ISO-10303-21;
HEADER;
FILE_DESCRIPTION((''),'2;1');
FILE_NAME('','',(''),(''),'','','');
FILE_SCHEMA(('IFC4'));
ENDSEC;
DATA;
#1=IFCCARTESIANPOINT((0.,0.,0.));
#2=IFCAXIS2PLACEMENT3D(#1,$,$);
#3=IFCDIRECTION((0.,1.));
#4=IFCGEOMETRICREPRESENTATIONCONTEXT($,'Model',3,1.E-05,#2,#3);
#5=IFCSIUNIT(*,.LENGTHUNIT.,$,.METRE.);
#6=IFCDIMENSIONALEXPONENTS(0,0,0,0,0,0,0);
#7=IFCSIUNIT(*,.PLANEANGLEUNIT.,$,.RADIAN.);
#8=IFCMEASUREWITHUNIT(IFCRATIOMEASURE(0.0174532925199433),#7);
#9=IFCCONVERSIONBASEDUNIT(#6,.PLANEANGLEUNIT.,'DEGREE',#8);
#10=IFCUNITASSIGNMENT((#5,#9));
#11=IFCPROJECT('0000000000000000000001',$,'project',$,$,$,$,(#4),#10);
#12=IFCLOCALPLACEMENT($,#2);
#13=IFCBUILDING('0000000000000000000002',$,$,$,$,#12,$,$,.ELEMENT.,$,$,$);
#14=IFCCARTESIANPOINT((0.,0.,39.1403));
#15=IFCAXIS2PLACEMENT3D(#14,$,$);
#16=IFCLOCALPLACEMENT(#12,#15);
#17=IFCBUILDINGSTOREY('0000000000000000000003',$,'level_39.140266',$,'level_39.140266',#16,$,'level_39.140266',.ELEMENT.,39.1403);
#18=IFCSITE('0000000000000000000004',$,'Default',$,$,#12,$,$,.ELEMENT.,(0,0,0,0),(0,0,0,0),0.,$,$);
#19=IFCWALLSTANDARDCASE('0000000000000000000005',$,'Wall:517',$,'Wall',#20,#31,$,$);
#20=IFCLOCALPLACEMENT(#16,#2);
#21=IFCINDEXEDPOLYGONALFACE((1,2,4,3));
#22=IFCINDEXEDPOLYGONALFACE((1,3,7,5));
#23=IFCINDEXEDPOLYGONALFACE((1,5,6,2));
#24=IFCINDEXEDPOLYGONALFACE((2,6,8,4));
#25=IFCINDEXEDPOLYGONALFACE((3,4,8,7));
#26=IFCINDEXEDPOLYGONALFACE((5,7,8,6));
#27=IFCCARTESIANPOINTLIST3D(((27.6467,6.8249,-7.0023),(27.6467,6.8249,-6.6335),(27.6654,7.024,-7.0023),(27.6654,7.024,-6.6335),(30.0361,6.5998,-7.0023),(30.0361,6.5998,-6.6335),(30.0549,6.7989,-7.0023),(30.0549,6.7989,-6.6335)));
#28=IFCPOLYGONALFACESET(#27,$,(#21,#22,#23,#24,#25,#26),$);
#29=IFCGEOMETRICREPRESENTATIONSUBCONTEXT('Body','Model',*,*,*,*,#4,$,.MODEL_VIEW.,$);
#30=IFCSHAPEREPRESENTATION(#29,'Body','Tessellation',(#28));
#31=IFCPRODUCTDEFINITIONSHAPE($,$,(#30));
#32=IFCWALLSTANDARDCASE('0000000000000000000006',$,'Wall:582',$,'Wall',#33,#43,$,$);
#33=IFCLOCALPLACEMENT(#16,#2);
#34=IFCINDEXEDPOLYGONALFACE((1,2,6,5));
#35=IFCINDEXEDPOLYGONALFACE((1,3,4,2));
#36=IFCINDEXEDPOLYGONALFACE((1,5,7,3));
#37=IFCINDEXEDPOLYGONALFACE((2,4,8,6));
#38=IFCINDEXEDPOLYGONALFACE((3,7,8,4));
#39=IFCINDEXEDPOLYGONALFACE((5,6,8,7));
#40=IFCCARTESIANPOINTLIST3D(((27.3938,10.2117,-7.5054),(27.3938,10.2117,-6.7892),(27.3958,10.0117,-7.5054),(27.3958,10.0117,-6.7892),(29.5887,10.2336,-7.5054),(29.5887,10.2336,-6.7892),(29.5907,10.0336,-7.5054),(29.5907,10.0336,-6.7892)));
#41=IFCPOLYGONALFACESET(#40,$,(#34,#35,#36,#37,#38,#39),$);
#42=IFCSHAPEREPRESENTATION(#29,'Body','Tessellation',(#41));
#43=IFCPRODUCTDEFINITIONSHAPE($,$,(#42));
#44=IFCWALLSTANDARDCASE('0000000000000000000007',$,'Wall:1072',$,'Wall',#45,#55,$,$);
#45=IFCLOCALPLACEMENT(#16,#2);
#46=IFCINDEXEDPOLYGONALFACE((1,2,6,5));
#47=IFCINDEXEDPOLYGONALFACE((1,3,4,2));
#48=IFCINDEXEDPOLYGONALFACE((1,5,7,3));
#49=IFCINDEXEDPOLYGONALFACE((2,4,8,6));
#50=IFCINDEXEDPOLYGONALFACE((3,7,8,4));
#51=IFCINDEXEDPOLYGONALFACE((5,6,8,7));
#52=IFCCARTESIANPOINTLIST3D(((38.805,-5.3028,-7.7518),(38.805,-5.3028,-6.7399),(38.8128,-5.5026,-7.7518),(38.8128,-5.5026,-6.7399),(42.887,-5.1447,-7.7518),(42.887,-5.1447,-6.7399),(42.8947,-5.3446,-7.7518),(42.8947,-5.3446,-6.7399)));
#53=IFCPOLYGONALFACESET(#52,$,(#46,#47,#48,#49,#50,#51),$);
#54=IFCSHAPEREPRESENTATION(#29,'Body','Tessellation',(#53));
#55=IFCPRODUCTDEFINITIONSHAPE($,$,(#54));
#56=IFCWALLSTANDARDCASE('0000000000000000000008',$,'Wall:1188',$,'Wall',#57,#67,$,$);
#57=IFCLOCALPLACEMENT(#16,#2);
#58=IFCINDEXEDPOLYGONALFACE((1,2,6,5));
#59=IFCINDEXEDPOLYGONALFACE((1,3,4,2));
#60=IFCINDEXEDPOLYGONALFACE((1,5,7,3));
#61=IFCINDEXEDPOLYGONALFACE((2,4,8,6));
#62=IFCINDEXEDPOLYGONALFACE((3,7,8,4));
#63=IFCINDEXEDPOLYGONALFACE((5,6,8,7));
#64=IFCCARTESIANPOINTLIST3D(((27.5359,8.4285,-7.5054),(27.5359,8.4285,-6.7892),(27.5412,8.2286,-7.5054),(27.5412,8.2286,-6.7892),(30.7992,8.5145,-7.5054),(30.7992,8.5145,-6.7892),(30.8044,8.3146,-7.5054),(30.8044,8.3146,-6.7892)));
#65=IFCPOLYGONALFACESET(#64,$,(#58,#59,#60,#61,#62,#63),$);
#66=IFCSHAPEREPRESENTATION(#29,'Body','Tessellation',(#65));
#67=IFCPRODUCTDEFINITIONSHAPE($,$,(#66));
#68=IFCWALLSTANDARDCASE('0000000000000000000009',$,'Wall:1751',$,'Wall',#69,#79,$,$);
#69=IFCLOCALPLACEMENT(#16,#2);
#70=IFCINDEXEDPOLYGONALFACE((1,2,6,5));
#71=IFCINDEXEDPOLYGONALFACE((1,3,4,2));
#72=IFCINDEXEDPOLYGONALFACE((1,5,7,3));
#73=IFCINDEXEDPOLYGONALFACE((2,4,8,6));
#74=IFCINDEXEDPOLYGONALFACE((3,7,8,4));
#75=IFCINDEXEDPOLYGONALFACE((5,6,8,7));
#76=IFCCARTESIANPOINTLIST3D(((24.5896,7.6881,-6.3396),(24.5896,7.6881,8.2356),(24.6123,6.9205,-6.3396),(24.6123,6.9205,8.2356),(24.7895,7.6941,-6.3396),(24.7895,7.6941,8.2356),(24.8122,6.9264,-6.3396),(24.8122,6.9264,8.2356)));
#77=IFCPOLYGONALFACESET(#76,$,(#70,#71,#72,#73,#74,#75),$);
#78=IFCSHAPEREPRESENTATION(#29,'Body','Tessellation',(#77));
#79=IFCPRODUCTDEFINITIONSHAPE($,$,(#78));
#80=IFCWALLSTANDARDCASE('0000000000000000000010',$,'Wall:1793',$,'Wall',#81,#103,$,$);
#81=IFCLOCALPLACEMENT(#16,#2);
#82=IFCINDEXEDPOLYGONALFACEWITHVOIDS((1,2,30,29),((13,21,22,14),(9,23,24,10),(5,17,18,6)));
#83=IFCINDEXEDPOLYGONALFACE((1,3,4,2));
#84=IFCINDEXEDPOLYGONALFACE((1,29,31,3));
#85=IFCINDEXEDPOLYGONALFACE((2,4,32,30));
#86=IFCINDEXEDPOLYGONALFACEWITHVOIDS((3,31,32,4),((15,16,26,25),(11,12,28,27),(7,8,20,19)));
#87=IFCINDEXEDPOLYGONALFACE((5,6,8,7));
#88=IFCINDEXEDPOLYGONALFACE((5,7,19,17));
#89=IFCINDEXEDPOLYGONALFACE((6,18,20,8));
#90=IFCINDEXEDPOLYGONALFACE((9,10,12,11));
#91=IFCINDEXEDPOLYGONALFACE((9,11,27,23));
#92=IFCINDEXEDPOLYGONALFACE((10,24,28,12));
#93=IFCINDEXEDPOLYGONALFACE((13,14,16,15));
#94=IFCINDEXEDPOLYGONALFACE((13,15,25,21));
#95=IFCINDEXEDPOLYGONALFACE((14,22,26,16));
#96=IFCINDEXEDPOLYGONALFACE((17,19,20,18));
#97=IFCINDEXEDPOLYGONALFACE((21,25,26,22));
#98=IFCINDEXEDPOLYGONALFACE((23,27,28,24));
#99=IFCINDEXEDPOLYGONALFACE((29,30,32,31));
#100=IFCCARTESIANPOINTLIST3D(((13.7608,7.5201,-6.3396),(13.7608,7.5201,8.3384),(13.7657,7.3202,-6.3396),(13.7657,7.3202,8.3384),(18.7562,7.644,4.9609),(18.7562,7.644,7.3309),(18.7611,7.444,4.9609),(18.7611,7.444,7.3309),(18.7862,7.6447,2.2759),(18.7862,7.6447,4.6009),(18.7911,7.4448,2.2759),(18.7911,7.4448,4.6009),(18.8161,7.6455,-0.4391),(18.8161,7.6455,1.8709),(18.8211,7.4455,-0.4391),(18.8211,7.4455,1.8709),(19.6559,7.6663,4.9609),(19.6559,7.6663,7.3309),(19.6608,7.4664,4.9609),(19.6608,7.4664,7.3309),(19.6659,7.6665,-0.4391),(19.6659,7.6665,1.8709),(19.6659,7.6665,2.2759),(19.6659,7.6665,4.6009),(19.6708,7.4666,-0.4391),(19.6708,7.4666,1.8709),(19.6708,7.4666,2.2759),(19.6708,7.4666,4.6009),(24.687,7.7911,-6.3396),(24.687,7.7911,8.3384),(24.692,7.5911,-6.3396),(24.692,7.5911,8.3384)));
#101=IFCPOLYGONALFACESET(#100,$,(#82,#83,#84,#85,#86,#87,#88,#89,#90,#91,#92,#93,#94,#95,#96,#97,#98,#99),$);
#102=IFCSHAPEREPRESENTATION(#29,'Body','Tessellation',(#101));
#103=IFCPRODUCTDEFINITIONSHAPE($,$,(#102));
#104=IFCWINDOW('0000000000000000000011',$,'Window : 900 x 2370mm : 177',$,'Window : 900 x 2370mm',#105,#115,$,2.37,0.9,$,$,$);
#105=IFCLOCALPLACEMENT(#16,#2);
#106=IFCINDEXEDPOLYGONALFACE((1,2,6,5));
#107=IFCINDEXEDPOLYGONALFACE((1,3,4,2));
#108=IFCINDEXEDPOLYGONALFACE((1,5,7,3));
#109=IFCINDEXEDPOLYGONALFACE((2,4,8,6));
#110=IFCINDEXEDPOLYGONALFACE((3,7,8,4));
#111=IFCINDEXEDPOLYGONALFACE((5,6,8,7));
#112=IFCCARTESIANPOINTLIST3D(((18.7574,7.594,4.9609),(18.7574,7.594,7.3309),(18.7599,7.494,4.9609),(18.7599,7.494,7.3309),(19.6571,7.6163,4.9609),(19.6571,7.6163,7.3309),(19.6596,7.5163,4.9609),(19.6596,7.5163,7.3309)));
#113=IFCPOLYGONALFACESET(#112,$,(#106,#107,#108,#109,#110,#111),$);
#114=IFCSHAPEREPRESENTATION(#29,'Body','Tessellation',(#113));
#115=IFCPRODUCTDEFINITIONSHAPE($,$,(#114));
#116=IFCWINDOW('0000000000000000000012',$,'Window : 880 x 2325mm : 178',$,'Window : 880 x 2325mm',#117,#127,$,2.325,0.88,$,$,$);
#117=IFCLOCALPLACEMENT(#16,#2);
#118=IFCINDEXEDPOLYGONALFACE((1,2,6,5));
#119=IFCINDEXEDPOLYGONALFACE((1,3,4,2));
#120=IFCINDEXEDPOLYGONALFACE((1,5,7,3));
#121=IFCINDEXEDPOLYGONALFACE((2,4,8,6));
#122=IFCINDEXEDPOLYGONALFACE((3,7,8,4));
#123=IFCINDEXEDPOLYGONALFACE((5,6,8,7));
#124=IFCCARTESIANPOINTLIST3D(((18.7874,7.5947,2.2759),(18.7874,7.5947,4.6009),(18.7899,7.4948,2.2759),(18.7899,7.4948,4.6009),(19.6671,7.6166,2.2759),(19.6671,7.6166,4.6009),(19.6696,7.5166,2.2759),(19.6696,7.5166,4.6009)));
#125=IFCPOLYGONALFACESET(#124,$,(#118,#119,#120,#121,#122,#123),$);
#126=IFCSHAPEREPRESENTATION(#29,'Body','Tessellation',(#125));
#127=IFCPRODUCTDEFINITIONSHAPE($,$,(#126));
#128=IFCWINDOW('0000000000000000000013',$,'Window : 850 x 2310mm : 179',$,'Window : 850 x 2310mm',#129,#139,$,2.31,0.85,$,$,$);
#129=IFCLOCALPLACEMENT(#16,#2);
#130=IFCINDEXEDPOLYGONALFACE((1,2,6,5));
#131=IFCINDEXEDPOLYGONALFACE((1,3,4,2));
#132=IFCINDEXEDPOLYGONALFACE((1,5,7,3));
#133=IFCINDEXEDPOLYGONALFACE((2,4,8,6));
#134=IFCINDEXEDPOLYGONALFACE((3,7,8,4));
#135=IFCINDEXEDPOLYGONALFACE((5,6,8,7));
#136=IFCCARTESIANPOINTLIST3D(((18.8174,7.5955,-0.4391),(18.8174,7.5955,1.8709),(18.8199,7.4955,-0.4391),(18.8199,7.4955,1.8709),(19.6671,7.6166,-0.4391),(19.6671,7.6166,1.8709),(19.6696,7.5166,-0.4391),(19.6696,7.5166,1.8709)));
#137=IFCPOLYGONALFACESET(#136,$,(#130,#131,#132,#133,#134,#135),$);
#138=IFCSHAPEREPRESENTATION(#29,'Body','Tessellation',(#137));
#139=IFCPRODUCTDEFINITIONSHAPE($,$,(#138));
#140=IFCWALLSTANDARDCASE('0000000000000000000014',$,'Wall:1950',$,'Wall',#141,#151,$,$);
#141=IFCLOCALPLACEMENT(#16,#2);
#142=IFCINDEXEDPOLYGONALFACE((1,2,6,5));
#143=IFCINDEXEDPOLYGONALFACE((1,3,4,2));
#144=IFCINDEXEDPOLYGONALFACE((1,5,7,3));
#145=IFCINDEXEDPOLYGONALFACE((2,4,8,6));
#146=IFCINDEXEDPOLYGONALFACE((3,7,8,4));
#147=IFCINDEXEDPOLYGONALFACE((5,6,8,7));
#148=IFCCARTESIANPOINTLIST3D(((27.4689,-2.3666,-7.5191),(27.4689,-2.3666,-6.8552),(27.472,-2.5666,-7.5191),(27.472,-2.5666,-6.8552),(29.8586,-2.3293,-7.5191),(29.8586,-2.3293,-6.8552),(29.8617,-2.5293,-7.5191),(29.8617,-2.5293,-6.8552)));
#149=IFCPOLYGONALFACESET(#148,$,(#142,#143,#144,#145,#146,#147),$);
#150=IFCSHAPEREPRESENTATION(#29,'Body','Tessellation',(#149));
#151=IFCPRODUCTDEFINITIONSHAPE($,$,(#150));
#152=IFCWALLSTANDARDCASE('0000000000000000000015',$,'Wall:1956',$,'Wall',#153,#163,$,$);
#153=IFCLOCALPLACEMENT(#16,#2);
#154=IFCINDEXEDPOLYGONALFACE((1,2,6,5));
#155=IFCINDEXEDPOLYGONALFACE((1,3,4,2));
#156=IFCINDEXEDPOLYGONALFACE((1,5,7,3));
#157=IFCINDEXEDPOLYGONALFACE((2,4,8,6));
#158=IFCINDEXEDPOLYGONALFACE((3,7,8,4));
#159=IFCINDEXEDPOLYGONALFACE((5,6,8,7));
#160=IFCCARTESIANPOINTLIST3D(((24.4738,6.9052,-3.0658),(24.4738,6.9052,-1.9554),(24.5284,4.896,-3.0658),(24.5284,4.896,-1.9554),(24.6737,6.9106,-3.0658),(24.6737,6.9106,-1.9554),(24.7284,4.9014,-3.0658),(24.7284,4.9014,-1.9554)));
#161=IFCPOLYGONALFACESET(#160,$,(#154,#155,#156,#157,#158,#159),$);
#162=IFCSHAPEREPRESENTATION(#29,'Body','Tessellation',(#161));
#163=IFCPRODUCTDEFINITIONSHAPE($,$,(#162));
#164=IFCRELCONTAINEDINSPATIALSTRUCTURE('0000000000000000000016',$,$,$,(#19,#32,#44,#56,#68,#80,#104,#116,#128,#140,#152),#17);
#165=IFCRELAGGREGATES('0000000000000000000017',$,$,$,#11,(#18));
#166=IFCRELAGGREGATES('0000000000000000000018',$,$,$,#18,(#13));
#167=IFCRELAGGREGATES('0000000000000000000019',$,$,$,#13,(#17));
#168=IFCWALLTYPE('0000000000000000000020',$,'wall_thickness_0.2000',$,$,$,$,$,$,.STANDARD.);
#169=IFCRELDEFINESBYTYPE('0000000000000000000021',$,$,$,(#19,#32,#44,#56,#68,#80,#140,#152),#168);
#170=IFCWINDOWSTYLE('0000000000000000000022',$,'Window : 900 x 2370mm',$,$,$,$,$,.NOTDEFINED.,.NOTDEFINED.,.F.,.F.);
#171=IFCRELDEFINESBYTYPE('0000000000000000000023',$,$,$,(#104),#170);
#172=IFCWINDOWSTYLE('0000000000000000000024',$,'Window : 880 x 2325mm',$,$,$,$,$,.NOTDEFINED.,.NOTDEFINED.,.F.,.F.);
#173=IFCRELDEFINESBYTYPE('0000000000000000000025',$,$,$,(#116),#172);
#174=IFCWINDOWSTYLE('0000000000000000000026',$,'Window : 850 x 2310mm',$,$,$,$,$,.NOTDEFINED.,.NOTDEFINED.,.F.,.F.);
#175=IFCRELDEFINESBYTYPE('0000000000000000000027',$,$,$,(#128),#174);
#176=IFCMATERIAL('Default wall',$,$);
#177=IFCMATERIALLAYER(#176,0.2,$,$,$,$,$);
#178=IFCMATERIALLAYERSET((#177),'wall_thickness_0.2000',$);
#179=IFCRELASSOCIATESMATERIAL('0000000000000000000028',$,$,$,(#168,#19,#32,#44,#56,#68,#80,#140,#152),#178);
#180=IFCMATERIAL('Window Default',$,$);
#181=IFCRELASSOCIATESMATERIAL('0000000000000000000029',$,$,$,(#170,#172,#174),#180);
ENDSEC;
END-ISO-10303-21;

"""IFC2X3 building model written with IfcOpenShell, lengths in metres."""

from ifc_helpers import new_model, entity, si_unit, converted_unit, direction, frame, frame_2d, origin, origin_2d_with_axis, place, context, subcontext, project, spatial, polyline, rectangle, outline, extrude, source, transform, mapped, material, layer, layer_set, layer_usage, type_object, type_shapes, element, fill, save


model = new_model("IFC2X3")

# Units and contexts
model_context = context("Model", 3, precision=1e-05, world=origin(), true_north=direction((0.0, 1.0)))
body_context = subcontext(model_context, "Body", "Model", "MODEL_VIEW")
ifc_project = project(units=[si_unit("LENGTHUNIT", "METRE"), converted_unit("PLANEANGLEUNIT", "DEGREE", entity("IfcRatioMeasure", 0.0174532925199433), si_unit("PLANEANGLEUNIT", "RADIAN"), dimensions=[0, 0, 0, 0, 0, 0, 0])], contexts=[model_context])

# Site, building, storey
placement_1 = place(None, origin())
site = spatial("IfcSite", under=ifc_project, at=placement_1, Name="Default", CompositionType="ELEMENT", RefLatitude=(0, 0, 0, 0), RefLongitude=(0, 0, 0, 0), RefElevation=0.0)
building = spatial("IfcBuilding", under=site, at=placement_1, CompositionType="ELEMENT")
storey_placement = place(placement_1, frame((0.0, 0.0, 39.1403)))
storey = spatial("IfcBuildingStorey", under=building, at=storey_placement, Name="level_39.140266", ObjectType="level_39.140266", LongName="level_39.140266", CompositionType="ELEMENT", Elevation=39.1403)

# Walls
ifc_material_1 = material(Name="Default wall")
ifc_layer = layer(ifc_material_1, 0.2)
ifc_layer_set = layer_set([ifc_layer], Name="wall_thickness_0.2000")
ifc_layer_usage = layer_usage(ifc_layer_set, "AXIS2", "POSITIVE", -0.1)
wall_type = type_object("IfcWallType", Name="wall_thickness_0.2000", PredefinedType="STANDARD", material=ifc_layer_set)
placement_2 = place(placement_1, frame((0.0, 0.0, 32.138)))
wall_1_placement = place(placement_2, frame((27.6561, 6.9245, 0.0), z_axis=(0.0, 0.0, 1.0), x_axis=(0.995592, -0.093793, 0.0)))
element("IfcWallStandardCase", 1, at=wall_1_placement, inside=storey, type_object=wall_type, material=ifc_layer_usage, Name="Wall:517", ObjectType="Wall", context=body_context, shape_type="SweptSolid", body=[
    extrude(outline(polyline([(2.4, -0.1), (2.4, 0.1), (0.0, 0.1), (0.0, -0.1), (2.4, -0.1)])), origin(), (0.0, 0.0, 1.0), 0.3689),
])
placement_3 = place(placement_1, frame((0.0, 0.0, 31.6349)))
wall_2_placement = place(placement_3, frame((27.3948, 10.1117, 0.0), z_axis=(0.0, 0.0, 1.0), x_axis=(0.999951, 0.009947, 0.0)))
element("IfcWallStandardCase", 2, at=wall_2_placement, inside=storey, type_object=wall_type, material=ifc_layer_usage, Name="Wall:582", ObjectType="Wall", context=body_context, shape_type="SweptSolid", body=[
    extrude(outline(polyline([(2.195, -0.1), (2.195, 0.1), (0.0, 0.1), (0.0, -0.1), (2.195, -0.1)])), origin(), (0.0, 0.0, 1.0), 0.7162),
])
placement_4 = place(placement_1, frame((0.0, 0.0, 31.3885)))
wall_3_placement = place(placement_4, frame((38.8089, -5.4027, 0.0), z_axis=(0.0, 0.0, 1.0), x_axis=(0.999251, 0.038692, 0.0)))
element("IfcWallStandardCase", 3, at=wall_3_placement, inside=storey, type_object=wall_type, material=ifc_layer_usage, Name="Wall:1072", ObjectType="Wall", context=body_context, shape_type="SweptSolid", body=[
    extrude(outline(polyline([(4.085, -0.1), (4.085, 0.1), (0.0, 0.1), (0.0, -0.1), (4.085, -0.1)])), origin(), (0.0, 0.0, 1.0), 1.0119),
])
placement_5 = place(placement_1, frame((0.0, 0.0, 31.6349)))
wall_4_placement = place(placement_5, frame((27.5385, 8.3285, 0.0), z_axis=(0.0, 0.0, 1.0), x_axis=(0.999653, 0.026351, 0.0)))
element("IfcWallStandardCase", 4, at=wall_4_placement, inside=storey, type_object=wall_type, material=ifc_layer_usage, Name="Wall:1188", ObjectType="Wall", context=body_context, shape_type="SweptSolid", body=[
    extrude(outline(polyline([(3.2644, -0.1), (3.2644, 0.1), (0.0, 0.1), (0.0, -0.1), (3.2644, -0.1)])), origin(), (0.0, 0.0, 1.0), 0.7162),
])
placement_6 = place(placement_1, frame((0.0, 0.0, 32.8007)))
wall_5_placement = place(placement_6, frame((24.6895, 7.6911, 0.0), z_axis=(0.0, 0.0, 1.0), x_axis=(0.029652, -0.99956, 0.0)))
element("IfcWallStandardCase", 5, at=wall_5_placement, inside=storey, type_object=wall_type, material=ifc_layer_usage, Name="Wall:1751", ObjectType="Wall", context=body_context, shape_type="SweptSolid", body=[
    extrude(outline(polyline([(0.768, -0.1), (0.768, 0.1), (0.0, 0.1), (0.0, -0.1), (0.768, -0.1)])), origin(), (0.0, 0.0, 1.0), 14.5752),
])

# Wall, openings, windows
placement_7 = place(placement_1, frame((0.0, 0.0, 32.8007)))
wall_6_placement = place(placement_7, frame((24.6895, 7.6911, 0.0), z_axis=(0.0, 0.0, 1.0), x_axis=(-0.999693, -0.024794, 0.0)))
wall_6 = element("IfcWallStandardCase", 6, at=wall_6_placement, inside=storey, type_object=wall_type, material=ifc_layer_usage, Name="Wall:1793", ObjectType="Wall", context=body_context, shape_type="SweptSolid", body=[
    extrude(outline(polyline([(10.9296, -0.1), (10.9296, 0.1), (0.0, 0.1), (0.0, -0.1), (10.9296, -0.1)])), origin(), (0.0, 0.0, 1.0), 14.678),
])
opening_1_placement = place(wall_6_placement, frame((5.0327, -0.1, 11.3006)))
opening_1 = element("IfcOpeningElement", 7, at=opening_1_placement, cuts=wall_6, ObjectType="Opening", context=body_context, shape_type="SweptSolid", body=[
    extrude(rectangle(XDim=0.9, YDim=2.37, at=frame_2d((1.185, 0.45), x_axis=(0.0, 1.0))), frame((0.0, 0.0, 0.0), z_axis=(0.0, 1.0, 0.0), x_axis=(0.0, 0.0, 1.0)), (0.0, 0.0, 1.0), 0.2),
])
opening_2_placement = place(wall_6_placement, frame((5.0227, -0.1, 8.6156)))
opening_2 = element("IfcOpeningElement", 8, at=opening_2_placement, cuts=wall_6, ObjectType="Opening", context=body_context, shape_type="SweptSolid", body=[
    extrude(rectangle(XDim=0.88, YDim=2.325, at=frame_2d((1.1625, 0.44), x_axis=(0.0, 1.0))), frame((0.0, 0.0, 0.0), z_axis=(0.0, 1.0, 0.0), x_axis=(0.0, 0.0, 1.0)), (0.0, 0.0, 1.0), 0.2),
])
opening_3_placement = place(wall_6_placement, frame((5.0227, -0.1, 5.9006)))
opening_3 = element("IfcOpeningElement", 9, at=opening_3_placement, cuts=wall_6, ObjectType="Opening", context=body_context, shape_type="SweptSolid", body=[
    extrude(rectangle(XDim=0.85, YDim=2.31, at=frame_2d((1.155, 0.425), x_axis=(0.0, 1.0))), frame((0.0, 0.0, 0.0), z_axis=(0.0, 1.0, 0.0), x_axis=(0.0, 0.0, 1.0)), (0.0, 0.0, 1.0), 0.2),
])
ifc_material_2 = material(Name="Window Default")
window_style_1 = type_object("IfcWindowStyle", Name="Window : 900 x 2370mm", ConstructionType="NOTDEFINED", OperationType="NOTDEFINED", ParameterTakesPrecedence=False, Sizeable=False, material=ifc_material_2)
shared_shape_1 = source(origin(), body_context, "Body", "SweptSolid", [
    extrude(rectangle(XDim=0.1, YDim=0.9, at=origin_2d_with_axis()), frame((0.45, 0.1, 0.0), z_axis=(0.0, 0.0, 1.0), x_axis=(0.0, 1.0, 0.0)), (0.0, 0.0, 1.0), 2.37),
])
type_shapes(window_style_1, [shared_shape_1])
window_1_placement = place(opening_1_placement, origin())
window_1 = element("IfcWindow", 10, at=window_1_placement, inside=storey, type_object=window_style_1, Name="Window : 900 x 2370mm : 177", ObjectType="Window : 900 x 2370mm", OverallHeight=2.37, OverallWidth=0.9, context=body_context, shape_type="MappedRepresentation", body=[
    mapped(shared_shape_1, transform((0.0, 0.0, 0.0), scale=1.0)),
])
fill(opening_1, window_1)
window_style_2 = type_object("IfcWindowStyle", Name="Window : 880 x 2325mm", ConstructionType="NOTDEFINED", OperationType="NOTDEFINED", ParameterTakesPrecedence=False, Sizeable=False, material=ifc_material_2)
shared_shape_2 = source(origin(), body_context, "Body", "SweptSolid", [
    extrude(rectangle(XDim=0.1, YDim=0.88, at=origin_2d_with_axis()), frame((0.44, 0.1, 0.0), z_axis=(0.0, 0.0, 1.0), x_axis=(0.0, 1.0, 0.0)), (0.0, 0.0, 1.0), 2.325),
])
type_shapes(window_style_2, [shared_shape_2])
window_2_placement = place(opening_2_placement, origin())
window_2 = element("IfcWindow", 11, at=window_2_placement, inside=storey, type_object=window_style_2, Name="Window : 880 x 2325mm : 178", ObjectType="Window : 880 x 2325mm", OverallHeight=2.325, OverallWidth=0.88, context=body_context, shape_type="MappedRepresentation", body=[
    mapped(shared_shape_2, transform((0.0, 0.0, 0.0), scale=1.0)),
])
fill(opening_2, window_2)
window_style_3 = type_object("IfcWindowStyle", Name="Window : 850 x 2310mm", ConstructionType="NOTDEFINED", OperationType="NOTDEFINED", ParameterTakesPrecedence=False, Sizeable=False, material=ifc_material_2)
shared_shape_3 = source(origin(), body_context, "Body", "SweptSolid", [
    extrude(rectangle(XDim=0.1, YDim=0.85, at=origin_2d_with_axis()), frame((0.425, 0.1, 0.0), z_axis=(0.0, 0.0, 1.0), x_axis=(0.0, 1.0, 0.0)), (0.0, 0.0, 1.0), 2.31),
])
type_shapes(window_style_3, [shared_shape_3])
window_3_placement = place(opening_3_placement, origin())
window_3 = element("IfcWindow", 12, at=window_3_placement, inside=storey, type_object=window_style_3, Name="Window : 850 x 2310mm : 179", ObjectType="Window : 850 x 2310mm", OverallHeight=2.31, OverallWidth=0.85, context=body_context, shape_type="MappedRepresentation", body=[
    mapped(shared_shape_3, transform((0.0, 0.0, 0.0), scale=1.0)),
])
fill(opening_3, window_3)

# Walls
placement_8 = place(placement_1, frame((0.0, 0.0, 31.6212)))
wall_7_placement = place(placement_8, frame((27.4705, -2.4666, 0.0), z_axis=(0.0, 0.0, 1.0), x_axis=(0.999878, 0.015612, 0.0)))
element("IfcWallStandardCase", 13, at=wall_7_placement, inside=storey, type_object=wall_type, material=ifc_layer_usage, Name="Wall:1950", ObjectType="Wall", context=body_context, shape_type="SweptSolid", body=[
    extrude(outline(polyline([(2.39, -0.1), (2.39, 0.1), (0.0, 0.1), (0.0, -0.1), (2.39, -0.1)])), origin(), (0.0, 0.0, 1.0), 0.6638),
])
placement_9 = place(placement_1, frame((0.0, 0.0, 36.0745)))
wall_8_placement = place(placement_9, frame((24.6284, 4.8987, 0.0), z_axis=(0.0, 0.0, 1.0), x_axis=(-0.027193, 0.99963, 0.0)))
element("IfcWallStandardCase", 14, at=wall_8_placement, inside=storey, type_object=wall_type, material=ifc_layer_usage, Name="Wall:1956", ObjectType="Wall", context=body_context, shape_type="SweptSolid", body=[
    extrude(outline(polyline([(2.01, -0.1), (2.01, 0.1), (0.0, 0.1), (0.0, -0.1), (2.01, -0.1)])), origin(), (0.0, 0.0, 1.0), 1.1104),
])

save(model, "model.ifc")
